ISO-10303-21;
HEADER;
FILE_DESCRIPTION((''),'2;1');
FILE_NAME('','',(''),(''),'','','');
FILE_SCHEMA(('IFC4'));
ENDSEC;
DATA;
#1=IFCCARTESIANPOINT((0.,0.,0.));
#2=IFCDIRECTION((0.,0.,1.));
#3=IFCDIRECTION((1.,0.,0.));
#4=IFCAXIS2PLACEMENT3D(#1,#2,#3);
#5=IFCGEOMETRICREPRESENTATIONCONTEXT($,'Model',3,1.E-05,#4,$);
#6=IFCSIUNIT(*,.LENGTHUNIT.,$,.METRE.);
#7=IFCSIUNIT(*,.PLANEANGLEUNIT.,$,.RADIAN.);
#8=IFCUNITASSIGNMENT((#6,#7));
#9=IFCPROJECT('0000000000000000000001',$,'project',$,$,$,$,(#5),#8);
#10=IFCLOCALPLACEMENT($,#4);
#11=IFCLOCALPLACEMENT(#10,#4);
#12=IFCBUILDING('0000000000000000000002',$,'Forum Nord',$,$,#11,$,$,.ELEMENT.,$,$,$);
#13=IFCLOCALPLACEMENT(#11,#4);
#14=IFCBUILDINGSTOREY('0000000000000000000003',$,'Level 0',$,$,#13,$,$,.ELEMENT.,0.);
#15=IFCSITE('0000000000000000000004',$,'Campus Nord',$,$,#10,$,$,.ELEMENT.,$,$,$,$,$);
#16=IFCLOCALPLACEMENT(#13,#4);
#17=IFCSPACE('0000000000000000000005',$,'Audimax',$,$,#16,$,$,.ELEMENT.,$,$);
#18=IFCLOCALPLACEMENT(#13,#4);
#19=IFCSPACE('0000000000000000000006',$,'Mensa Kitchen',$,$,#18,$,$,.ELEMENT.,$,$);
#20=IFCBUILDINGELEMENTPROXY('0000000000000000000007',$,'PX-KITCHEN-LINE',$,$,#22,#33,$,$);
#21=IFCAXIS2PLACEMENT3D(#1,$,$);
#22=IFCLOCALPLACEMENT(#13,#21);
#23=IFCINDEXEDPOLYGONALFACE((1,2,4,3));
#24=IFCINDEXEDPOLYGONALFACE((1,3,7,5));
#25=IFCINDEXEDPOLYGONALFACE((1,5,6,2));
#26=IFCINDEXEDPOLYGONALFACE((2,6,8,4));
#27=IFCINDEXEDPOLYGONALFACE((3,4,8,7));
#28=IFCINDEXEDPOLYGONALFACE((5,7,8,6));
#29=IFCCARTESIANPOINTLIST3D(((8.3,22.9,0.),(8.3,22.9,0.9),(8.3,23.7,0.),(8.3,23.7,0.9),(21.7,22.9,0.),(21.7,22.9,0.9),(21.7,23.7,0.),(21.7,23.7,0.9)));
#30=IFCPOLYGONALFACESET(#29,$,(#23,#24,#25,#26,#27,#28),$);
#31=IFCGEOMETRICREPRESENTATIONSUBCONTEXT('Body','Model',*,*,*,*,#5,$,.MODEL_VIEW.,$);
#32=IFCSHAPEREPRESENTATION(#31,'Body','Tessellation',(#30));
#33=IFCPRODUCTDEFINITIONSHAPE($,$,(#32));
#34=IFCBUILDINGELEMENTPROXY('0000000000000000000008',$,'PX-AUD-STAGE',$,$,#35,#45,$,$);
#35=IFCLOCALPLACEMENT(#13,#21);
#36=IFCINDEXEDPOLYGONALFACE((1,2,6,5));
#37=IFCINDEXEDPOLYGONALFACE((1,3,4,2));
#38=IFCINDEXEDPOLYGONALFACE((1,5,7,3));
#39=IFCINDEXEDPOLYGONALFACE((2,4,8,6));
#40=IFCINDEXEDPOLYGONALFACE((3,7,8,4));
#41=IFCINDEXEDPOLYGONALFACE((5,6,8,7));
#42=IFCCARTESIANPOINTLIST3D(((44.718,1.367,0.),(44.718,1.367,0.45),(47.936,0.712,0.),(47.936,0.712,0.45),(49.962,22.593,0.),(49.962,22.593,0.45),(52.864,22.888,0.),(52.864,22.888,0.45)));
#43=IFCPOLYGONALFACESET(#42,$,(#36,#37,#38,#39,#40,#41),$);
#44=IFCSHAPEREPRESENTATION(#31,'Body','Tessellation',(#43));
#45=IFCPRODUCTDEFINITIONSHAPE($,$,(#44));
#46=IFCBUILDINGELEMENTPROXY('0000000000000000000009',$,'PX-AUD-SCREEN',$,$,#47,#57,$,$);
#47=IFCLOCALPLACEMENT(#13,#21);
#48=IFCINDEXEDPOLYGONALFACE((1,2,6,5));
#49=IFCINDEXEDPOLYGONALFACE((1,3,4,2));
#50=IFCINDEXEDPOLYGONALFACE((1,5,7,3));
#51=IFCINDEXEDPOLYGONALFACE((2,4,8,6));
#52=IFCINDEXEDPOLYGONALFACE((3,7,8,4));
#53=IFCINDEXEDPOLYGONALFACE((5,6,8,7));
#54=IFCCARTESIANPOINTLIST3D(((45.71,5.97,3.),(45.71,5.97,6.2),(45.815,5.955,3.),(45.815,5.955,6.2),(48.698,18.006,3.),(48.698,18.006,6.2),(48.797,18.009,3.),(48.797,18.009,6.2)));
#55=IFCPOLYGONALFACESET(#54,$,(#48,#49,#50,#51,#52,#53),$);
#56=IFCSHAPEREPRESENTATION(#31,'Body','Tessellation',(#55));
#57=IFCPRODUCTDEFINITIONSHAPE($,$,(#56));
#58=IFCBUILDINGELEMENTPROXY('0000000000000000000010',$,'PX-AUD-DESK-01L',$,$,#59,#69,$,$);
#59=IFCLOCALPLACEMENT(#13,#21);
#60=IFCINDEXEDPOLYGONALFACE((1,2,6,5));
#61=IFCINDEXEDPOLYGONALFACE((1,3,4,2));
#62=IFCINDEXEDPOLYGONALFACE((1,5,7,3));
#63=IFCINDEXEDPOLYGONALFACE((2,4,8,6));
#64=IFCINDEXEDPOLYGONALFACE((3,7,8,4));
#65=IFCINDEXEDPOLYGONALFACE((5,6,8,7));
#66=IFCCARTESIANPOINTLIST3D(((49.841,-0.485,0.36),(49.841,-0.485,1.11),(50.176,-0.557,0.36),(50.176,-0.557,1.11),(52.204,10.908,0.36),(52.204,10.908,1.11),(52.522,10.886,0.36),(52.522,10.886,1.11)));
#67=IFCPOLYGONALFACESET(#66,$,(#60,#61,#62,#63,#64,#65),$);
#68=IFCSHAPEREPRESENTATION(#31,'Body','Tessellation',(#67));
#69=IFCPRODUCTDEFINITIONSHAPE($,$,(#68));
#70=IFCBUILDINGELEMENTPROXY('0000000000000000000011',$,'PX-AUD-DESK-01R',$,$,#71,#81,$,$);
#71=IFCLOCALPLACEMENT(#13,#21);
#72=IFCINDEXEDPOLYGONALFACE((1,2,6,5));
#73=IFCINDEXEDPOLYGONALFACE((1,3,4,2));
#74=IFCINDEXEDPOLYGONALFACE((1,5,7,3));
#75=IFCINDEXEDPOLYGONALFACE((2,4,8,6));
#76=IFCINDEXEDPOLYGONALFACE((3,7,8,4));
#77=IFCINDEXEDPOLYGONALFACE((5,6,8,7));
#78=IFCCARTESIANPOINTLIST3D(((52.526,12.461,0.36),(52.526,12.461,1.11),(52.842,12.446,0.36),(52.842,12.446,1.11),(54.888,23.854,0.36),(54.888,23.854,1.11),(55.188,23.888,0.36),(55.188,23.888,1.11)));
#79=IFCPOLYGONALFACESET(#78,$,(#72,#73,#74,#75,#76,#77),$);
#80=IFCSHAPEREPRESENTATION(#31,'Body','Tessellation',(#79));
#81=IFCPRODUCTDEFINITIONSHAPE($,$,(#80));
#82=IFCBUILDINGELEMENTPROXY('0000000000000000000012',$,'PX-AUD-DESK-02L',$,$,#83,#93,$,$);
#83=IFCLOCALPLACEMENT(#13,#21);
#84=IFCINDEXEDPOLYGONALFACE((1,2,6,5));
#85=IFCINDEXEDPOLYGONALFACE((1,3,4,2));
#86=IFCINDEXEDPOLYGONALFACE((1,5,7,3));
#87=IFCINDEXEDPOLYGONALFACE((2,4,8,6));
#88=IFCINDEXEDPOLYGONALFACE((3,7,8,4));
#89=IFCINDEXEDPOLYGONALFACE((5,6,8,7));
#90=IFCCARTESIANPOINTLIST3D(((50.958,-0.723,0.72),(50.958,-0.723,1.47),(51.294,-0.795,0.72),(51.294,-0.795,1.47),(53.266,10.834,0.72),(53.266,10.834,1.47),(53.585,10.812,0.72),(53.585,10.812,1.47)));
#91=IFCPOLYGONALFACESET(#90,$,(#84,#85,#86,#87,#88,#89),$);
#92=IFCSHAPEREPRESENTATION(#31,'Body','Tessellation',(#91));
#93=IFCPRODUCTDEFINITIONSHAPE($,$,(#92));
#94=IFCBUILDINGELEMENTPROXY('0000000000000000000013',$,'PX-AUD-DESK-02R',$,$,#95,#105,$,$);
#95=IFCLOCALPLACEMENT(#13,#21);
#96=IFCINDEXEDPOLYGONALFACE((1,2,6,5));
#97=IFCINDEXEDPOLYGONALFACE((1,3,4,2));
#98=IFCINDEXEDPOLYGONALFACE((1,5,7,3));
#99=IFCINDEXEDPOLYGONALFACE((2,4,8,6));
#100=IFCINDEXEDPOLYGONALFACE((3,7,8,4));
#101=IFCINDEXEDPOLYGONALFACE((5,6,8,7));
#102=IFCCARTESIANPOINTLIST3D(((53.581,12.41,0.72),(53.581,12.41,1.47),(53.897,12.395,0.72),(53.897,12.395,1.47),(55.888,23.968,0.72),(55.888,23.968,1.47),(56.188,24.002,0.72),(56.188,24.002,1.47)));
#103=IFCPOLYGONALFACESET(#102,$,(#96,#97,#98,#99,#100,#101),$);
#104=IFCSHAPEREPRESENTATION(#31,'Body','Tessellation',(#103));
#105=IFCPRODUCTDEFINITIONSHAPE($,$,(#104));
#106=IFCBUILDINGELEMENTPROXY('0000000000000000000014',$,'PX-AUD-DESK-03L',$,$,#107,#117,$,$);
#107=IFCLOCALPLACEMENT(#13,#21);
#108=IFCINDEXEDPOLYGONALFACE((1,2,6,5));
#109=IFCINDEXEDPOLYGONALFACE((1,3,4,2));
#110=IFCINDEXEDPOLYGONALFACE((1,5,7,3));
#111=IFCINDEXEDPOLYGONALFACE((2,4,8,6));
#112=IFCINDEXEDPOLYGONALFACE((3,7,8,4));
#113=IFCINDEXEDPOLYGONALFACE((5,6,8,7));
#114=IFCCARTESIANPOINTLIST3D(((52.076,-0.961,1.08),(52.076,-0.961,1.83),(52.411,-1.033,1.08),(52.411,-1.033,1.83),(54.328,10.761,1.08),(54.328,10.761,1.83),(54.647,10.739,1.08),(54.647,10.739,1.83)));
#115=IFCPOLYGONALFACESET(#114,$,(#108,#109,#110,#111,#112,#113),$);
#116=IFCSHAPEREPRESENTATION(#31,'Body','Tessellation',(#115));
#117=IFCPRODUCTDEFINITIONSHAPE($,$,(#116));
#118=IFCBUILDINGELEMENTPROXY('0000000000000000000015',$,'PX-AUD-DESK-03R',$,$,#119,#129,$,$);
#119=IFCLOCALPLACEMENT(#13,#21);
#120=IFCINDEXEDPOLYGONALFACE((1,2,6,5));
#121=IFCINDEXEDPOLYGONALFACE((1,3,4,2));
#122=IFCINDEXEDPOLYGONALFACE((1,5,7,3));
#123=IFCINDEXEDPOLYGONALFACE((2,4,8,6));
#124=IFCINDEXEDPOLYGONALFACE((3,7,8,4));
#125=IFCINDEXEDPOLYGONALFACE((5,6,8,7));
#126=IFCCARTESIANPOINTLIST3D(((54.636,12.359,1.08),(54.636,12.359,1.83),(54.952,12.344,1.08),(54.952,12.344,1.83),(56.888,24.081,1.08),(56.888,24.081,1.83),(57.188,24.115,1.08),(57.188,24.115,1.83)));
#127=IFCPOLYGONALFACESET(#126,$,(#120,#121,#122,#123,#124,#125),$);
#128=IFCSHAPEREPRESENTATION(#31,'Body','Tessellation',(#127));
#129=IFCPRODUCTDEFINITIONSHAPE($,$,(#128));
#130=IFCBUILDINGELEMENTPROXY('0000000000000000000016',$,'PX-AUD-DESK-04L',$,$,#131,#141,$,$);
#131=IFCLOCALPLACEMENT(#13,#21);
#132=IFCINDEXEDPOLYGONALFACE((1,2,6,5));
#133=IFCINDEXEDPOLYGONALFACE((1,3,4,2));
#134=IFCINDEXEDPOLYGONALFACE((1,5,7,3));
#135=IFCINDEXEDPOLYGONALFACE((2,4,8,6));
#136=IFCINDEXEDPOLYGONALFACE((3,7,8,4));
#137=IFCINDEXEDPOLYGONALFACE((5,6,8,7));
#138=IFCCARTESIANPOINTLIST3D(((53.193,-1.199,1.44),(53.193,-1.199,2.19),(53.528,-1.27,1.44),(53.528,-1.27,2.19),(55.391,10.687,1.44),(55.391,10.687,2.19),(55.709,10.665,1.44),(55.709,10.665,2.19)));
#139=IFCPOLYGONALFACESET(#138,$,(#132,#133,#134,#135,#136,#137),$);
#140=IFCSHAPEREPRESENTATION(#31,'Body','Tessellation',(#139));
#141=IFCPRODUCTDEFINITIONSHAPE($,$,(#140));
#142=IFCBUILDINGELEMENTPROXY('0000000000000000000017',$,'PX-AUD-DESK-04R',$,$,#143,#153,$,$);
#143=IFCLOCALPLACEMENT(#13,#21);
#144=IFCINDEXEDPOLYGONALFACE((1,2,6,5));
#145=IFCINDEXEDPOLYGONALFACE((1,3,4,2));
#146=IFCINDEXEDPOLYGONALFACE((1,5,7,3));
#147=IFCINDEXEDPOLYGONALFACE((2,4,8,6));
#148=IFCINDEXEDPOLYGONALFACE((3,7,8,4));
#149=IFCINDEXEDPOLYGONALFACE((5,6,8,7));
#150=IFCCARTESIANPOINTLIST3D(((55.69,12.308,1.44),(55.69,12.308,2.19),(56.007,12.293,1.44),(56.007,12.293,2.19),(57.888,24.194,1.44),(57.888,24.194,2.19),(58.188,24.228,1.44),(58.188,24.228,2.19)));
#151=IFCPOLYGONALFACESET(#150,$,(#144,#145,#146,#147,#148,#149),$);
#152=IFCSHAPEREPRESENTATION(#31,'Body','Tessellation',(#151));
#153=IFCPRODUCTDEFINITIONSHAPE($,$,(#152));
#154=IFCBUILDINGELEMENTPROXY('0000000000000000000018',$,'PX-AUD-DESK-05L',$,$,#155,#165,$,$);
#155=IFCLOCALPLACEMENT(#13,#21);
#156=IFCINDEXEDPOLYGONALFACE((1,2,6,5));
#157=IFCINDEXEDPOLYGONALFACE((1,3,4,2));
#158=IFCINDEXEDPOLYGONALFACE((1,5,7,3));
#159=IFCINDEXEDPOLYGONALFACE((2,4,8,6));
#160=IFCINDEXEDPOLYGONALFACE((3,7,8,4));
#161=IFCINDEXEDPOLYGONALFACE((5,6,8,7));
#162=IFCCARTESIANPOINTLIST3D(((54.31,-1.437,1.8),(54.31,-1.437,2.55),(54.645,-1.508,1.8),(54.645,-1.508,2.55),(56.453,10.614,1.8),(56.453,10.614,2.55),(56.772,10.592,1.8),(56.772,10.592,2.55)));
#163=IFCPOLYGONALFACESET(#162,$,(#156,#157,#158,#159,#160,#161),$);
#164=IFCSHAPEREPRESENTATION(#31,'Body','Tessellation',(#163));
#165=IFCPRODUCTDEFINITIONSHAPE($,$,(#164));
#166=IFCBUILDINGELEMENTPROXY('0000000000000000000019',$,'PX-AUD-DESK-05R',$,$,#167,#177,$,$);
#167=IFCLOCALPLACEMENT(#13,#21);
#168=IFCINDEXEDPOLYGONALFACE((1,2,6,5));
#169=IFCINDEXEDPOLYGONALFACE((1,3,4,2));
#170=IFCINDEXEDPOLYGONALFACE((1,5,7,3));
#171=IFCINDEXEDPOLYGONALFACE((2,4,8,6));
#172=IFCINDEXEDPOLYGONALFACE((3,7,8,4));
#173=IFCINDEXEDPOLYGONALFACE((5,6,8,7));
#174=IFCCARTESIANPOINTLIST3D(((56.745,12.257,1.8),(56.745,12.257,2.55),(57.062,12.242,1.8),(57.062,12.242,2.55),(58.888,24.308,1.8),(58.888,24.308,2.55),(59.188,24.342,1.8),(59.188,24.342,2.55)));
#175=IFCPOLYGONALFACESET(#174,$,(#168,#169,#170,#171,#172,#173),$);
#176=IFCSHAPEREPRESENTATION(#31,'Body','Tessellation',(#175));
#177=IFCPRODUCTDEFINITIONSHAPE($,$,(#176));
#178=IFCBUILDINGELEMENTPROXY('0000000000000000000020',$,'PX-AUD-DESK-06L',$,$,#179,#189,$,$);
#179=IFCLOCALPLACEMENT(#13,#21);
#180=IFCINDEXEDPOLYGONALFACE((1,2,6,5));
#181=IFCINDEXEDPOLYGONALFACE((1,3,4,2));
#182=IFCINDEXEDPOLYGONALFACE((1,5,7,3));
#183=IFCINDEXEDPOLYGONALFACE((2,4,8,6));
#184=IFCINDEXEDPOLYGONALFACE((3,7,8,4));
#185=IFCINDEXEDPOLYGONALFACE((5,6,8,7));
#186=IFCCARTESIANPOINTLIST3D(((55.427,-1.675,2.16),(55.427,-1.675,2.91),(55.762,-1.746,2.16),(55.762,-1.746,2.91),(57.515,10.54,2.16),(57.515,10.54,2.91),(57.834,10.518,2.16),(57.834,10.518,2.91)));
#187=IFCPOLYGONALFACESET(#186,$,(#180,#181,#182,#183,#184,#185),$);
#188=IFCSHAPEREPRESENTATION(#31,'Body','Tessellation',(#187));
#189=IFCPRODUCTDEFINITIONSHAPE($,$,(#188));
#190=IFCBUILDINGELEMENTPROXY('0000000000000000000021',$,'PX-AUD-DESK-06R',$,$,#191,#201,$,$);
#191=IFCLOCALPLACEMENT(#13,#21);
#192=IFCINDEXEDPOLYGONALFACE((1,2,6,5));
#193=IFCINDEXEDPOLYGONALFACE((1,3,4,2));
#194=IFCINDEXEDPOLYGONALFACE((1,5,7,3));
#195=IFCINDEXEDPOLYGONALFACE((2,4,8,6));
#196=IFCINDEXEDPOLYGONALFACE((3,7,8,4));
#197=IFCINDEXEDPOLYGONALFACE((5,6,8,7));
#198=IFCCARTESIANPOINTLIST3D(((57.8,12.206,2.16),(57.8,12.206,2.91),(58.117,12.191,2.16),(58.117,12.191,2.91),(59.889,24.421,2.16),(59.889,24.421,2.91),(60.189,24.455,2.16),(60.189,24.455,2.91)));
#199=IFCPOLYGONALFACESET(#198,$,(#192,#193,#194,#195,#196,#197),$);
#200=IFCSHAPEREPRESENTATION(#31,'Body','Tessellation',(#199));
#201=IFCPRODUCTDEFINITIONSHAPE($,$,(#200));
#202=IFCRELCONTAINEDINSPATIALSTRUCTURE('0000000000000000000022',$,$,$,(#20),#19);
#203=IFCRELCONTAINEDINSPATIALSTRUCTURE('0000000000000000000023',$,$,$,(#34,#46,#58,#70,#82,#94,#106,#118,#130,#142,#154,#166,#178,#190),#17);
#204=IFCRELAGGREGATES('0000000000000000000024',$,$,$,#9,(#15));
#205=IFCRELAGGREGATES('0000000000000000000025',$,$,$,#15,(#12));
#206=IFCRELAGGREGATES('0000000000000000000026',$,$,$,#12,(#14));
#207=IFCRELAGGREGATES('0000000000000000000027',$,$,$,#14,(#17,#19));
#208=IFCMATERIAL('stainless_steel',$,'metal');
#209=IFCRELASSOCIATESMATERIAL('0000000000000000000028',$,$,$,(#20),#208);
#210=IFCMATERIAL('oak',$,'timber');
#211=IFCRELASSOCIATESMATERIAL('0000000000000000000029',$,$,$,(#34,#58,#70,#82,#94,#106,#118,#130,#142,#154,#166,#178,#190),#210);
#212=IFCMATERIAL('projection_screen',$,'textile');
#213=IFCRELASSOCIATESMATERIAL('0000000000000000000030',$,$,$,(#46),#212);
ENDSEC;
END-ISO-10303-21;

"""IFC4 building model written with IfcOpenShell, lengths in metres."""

from ifc_helpers import new_model, si_unit, frame, origin_with_axes, place, context, subcontext, project, spatial, polyline, outline, extrude, material, element, save


model = new_model("IFC4")

# Units and contexts
model_context = context("Model", 3, precision=1e-05, world=origin_with_axes())
body_context = subcontext(model_context, "Body", "Model", "MODEL_VIEW")
ifc_project = project(units=[si_unit("LENGTHUNIT", "METRE"), si_unit("PLANEANGLEUNIT", "RADIAN")], contexts=[model_context])

# Site, building, storey, space
site_placement = place(None, origin_with_axes())
site = spatial("IfcSite", under=ifc_project, at=site_placement, Name="Campus Nord", CompositionType="ELEMENT")
building_placement = place(site_placement, origin_with_axes())
building = spatial("IfcBuilding", under=site, at=building_placement, Name="Forum Nord", CompositionType="ELEMENT")
storey_placement = place(building_placement, origin_with_axes())
storey = spatial("IfcBuildingStorey", under=building, at=storey_placement, Name="Level 0", CompositionType="ELEMENT", Elevation=0.0)
space_1_placement = place(storey_placement, origin_with_axes())
space_1 = spatial("IfcSpace", under=storey, at=space_1_placement, Name="Audimax", CompositionType="ELEMENT")

# Shared definitions
ifc_material_1 = material(Name="oak", Category="timber")

# Shared definitions
space_2_placement = place(storey_placement, origin_with_axes())
space_2 = spatial("IfcSpace", under=storey, at=space_2_placement, Name="Mensa Kitchen", CompositionType="ELEMENT")

# Building element proxies
ifc_material_2 = material(Name="stainless_steel", Category="metal")
proxy_1_placement = place(storey_placement, origin_with_axes())
element("IfcBuildingElementProxy", 1, at=proxy_1_placement, inside=space_2, material=ifc_material_2, Name="PX-KITCHEN-LINE", context=body_context, shape_type="SweptSolid", body=[
    extrude(outline(polyline([(8.3, 22.9), (21.7, 22.9), (21.7, 23.7), (8.3, 23.7), (8.3, 22.9)])), origin_with_axes(), (0.0, 0.0, 1.0), 0.9),
])
proxy_2_placement = place(storey_placement, origin_with_axes())
element("IfcBuildingElementProxy", 2, at=proxy_2_placement, inside=space_1, material=ifc_material_1, Name="PX-AUD-STAGE", context=body_context, shape_type="SweptSolid", body=[
    extrude(outline(polyline([(44.718, 1.367), (47.936, 0.712), (52.864, 22.888), (49.962, 22.593), (44.718, 1.367)])), origin_with_axes(), (0.0, 0.0, 1.0), 0.45),
])
ifc_material_3 = material(Name="projection_screen", Category="textile")
proxy_3_placement = place(storey_placement, frame((0.0, 0.0, 3.0), z_axis=(0.0, 0.0, 1.0), x_axis=(1.0, 0.0, 0.0)))
element("IfcBuildingElementProxy", 3, at=proxy_3_placement, inside=space_1, material=ifc_material_3, Name="PX-AUD-SCREEN", context=body_context, shape_type="SweptSolid", body=[
    extrude(outline(polyline([(45.71, 5.97), (45.815, 5.955), (48.797, 18.009), (48.698, 18.006), (45.71, 5.97)])), origin_with_axes(), (0.0, 0.0, 1.0), 3.2),
])
proxy_4_placement = place(storey_placement, frame((0.0, 0.0, 0.36), z_axis=(0.0, 0.0, 1.0), x_axis=(1.0, 0.0, 0.0)))
element("IfcBuildingElementProxy", 4, at=proxy_4_placement, inside=space_1, material=ifc_material_1, Name="PX-AUD-DESK-01L", context=body_context, shape_type="SweptSolid", body=[
    extrude(outline(polyline([(49.841, -0.485), (50.176, -0.557), (52.522, 10.886), (52.204, 10.908), (49.841, -0.485)])), origin_with_axes(), (0.0, 0.0, 1.0), 0.75),
])
proxy_5_placement = place(storey_placement, frame((0.0, 0.0, 0.36), z_axis=(0.0, 0.0, 1.0), x_axis=(1.0, 0.0, 0.0)))
element("IfcBuildingElementProxy", 5, at=proxy_5_placement, inside=space_1, material=ifc_material_1, Name="PX-AUD-DESK-01R", context=body_context, shape_type="SweptSolid", body=[
    extrude(outline(polyline([(52.526, 12.461), (52.842, 12.446), (55.188, 23.888), (54.888, 23.854), (52.526, 12.461)])), origin_with_axes(), (0.0, 0.0, 1.0), 0.75),
])
proxy_6_placement = place(storey_placement, frame((0.0, 0.0, 0.72), z_axis=(0.0, 0.0, 1.0), x_axis=(1.0, 0.0, 0.0)))
element("IfcBuildingElementProxy", 6, at=proxy_6_placement, inside=space_1, material=ifc_material_1, Name="PX-AUD-DESK-02L", context=body_context, shape_type="SweptSolid", body=[
    extrude(outline(polyline([(50.958, -0.723), (51.294, -0.795), (53.585, 10.812), (53.266, 10.834), (50.958, -0.723)])), origin_with_axes(), (0.0, 0.0, 1.0), 0.75),
])
proxy_7_placement = place(storey_placement, frame((0.0, 0.0, 0.72), z_axis=(0.0, 0.0, 1.0), x_axis=(1.0, 0.0, 0.0)))
element("IfcBuildingElementProxy", 7, at=proxy_7_placement, inside=space_1, material=ifc_material_1, Name="PX-AUD-DESK-02R", context=body_context, shape_type="SweptSolid", body=[
    extrude(outline(polyline([(53.581, 12.41), (53.897, 12.395), (56.188, 24.002), (55.888, 23.968), (53.581, 12.41)])), origin_with_axes(), (0.0, 0.0, 1.0), 0.75),
])
proxy_8_placement = place(storey_placement, frame((0.0, 0.0, 1.08), z_axis=(0.0, 0.0, 1.0), x_axis=(1.0, 0.0, 0.0)))
element("IfcBuildingElementProxy", 8, at=proxy_8_placement, inside=space_1, material=ifc_material_1, Name="PX-AUD-DESK-03L", context=body_context, shape_type="SweptSolid", body=[
    extrude(outline(polyline([(52.076, -0.961), (52.411, -1.033), (54.647, 10.739), (54.328, 10.761), (52.076, -0.961)])), origin_with_axes(), (0.0, 0.0, 1.0), 0.75),
])
proxy_9_placement = place(storey_placement, frame((0.0, 0.0, 1.08), z_axis=(0.0, 0.0, 1.0), x_axis=(1.0, 0.0, 0.0)))
element("IfcBuildingElementProxy", 9, at=proxy_9_placement, inside=space_1, material=ifc_material_1, Name="PX-AUD-DESK-03R", context=body_context, shape_type="SweptSolid", body=[
    extrude(outline(polyline([(54.636, 12.359), (54.952, 12.344), (57.188, 24.115), (56.888, 24.081), (54.636, 12.359)])), origin_with_axes(), (0.0, 0.0, 1.0), 0.75),
])
proxy_10_placement = place(storey_placement, frame((0.0, 0.0, 1.44), z_axis=(0.0, 0.0, 1.0), x_axis=(1.0, 0.0, 0.0)))
element("IfcBuildingElementProxy", 10, at=proxy_10_placement, inside=space_1, material=ifc_material_1, Name="PX-AUD-DESK-04L", context=body_context, shape_type="SweptSolid", body=[
    extrude(outline(polyline([(53.193, -1.199), (53.528, -1.27), (55.709, 10.665), (55.391, 10.687), (53.193, -1.199)])), origin_with_axes(), (0.0, 0.0, 1.0), 0.75),
])
proxy_11_placement = place(storey_placement, frame((0.0, 0.0, 1.44), z_axis=(0.0, 0.0, 1.0), x_axis=(1.0, 0.0, 0.0)))
element("IfcBuildingElementProxy", 11, at=proxy_11_placement, inside=space_1, material=ifc_material_1, Name="PX-AUD-DESK-04R", context=body_context, shape_type="SweptSolid", body=[
    extrude(outline(polyline([(55.69, 12.308), (56.007, 12.293), (58.188, 24.228), (57.888, 24.194), (55.69, 12.308)])), origin_with_axes(), (0.0, 0.0, 1.0), 0.75),
])
proxy_12_placement = place(storey_placement, frame((0.0, 0.0, 1.8), z_axis=(0.0, 0.0, 1.0), x_axis=(1.0, 0.0, 0.0)))
element("IfcBuildingElementProxy", 12, at=proxy_12_placement, inside=space_1, material=ifc_material_1, Name="PX-AUD-DESK-05L", context=body_context, shape_type="SweptSolid", body=[
    extrude(outline(polyline([(54.31, -1.437), (54.645, -1.508), (56.772, 10.592), (56.453, 10.614), (54.31, -1.437)])), origin_with_axes(), (0.0, 0.0, 1.0), 0.75),
])
proxy_13_placement = place(storey_placement, frame((0.0, 0.0, 1.8), z_axis=(0.0, 0.0, 1.0), x_axis=(1.0, 0.0, 0.0)))
element("IfcBuildingElementProxy", 13, at=proxy_13_placement, inside=space_1, material=ifc_material_1, Name="PX-AUD-DESK-05R", context=body_context, shape_type="SweptSolid", body=[
    extrude(outline(polyline([(56.745, 12.257), (57.062, 12.242), (59.188, 24.342), (58.888, 24.308), (56.745, 12.257)])), origin_with_axes(), (0.0, 0.0, 1.0), 0.75),
])
proxy_14_placement = place(storey_placement, frame((0.0, 0.0, 2.16), z_axis=(0.0, 0.0, 1.0), x_axis=(1.0, 0.0, 0.0)))
element("IfcBuildingElementProxy", 14, at=proxy_14_placement, inside=space_1, material=ifc_material_1, Name="PX-AUD-DESK-06L", context=body_context, shape_type="SweptSolid", body=[
    extrude(outline(polyline([(55.427, -1.675), (55.762, -1.746), (57.834, 10.518), (57.515, 10.54), (55.427, -1.675)])), origin_with_axes(), (0.0, 0.0, 1.0), 0.75),
])
proxy_15_placement = place(storey_placement, frame((0.0, 0.0, 2.16), z_axis=(0.0, 0.0, 1.0), x_axis=(1.0, 0.0, 0.0)))
element("IfcBuildingElementProxy", 15, at=proxy_15_placement, inside=space_1, material=ifc_material_1, Name="PX-AUD-DESK-06R", context=body_context, shape_type="SweptSolid", body=[
    extrude(outline(polyline([(57.8, 12.206), (58.117, 12.191), (60.189, 24.455), (59.889, 24.421), (57.8, 12.206)])), origin_with_axes(), (0.0, 0.0, 1.0), 0.75),
])

save(model, "model.ifc")
